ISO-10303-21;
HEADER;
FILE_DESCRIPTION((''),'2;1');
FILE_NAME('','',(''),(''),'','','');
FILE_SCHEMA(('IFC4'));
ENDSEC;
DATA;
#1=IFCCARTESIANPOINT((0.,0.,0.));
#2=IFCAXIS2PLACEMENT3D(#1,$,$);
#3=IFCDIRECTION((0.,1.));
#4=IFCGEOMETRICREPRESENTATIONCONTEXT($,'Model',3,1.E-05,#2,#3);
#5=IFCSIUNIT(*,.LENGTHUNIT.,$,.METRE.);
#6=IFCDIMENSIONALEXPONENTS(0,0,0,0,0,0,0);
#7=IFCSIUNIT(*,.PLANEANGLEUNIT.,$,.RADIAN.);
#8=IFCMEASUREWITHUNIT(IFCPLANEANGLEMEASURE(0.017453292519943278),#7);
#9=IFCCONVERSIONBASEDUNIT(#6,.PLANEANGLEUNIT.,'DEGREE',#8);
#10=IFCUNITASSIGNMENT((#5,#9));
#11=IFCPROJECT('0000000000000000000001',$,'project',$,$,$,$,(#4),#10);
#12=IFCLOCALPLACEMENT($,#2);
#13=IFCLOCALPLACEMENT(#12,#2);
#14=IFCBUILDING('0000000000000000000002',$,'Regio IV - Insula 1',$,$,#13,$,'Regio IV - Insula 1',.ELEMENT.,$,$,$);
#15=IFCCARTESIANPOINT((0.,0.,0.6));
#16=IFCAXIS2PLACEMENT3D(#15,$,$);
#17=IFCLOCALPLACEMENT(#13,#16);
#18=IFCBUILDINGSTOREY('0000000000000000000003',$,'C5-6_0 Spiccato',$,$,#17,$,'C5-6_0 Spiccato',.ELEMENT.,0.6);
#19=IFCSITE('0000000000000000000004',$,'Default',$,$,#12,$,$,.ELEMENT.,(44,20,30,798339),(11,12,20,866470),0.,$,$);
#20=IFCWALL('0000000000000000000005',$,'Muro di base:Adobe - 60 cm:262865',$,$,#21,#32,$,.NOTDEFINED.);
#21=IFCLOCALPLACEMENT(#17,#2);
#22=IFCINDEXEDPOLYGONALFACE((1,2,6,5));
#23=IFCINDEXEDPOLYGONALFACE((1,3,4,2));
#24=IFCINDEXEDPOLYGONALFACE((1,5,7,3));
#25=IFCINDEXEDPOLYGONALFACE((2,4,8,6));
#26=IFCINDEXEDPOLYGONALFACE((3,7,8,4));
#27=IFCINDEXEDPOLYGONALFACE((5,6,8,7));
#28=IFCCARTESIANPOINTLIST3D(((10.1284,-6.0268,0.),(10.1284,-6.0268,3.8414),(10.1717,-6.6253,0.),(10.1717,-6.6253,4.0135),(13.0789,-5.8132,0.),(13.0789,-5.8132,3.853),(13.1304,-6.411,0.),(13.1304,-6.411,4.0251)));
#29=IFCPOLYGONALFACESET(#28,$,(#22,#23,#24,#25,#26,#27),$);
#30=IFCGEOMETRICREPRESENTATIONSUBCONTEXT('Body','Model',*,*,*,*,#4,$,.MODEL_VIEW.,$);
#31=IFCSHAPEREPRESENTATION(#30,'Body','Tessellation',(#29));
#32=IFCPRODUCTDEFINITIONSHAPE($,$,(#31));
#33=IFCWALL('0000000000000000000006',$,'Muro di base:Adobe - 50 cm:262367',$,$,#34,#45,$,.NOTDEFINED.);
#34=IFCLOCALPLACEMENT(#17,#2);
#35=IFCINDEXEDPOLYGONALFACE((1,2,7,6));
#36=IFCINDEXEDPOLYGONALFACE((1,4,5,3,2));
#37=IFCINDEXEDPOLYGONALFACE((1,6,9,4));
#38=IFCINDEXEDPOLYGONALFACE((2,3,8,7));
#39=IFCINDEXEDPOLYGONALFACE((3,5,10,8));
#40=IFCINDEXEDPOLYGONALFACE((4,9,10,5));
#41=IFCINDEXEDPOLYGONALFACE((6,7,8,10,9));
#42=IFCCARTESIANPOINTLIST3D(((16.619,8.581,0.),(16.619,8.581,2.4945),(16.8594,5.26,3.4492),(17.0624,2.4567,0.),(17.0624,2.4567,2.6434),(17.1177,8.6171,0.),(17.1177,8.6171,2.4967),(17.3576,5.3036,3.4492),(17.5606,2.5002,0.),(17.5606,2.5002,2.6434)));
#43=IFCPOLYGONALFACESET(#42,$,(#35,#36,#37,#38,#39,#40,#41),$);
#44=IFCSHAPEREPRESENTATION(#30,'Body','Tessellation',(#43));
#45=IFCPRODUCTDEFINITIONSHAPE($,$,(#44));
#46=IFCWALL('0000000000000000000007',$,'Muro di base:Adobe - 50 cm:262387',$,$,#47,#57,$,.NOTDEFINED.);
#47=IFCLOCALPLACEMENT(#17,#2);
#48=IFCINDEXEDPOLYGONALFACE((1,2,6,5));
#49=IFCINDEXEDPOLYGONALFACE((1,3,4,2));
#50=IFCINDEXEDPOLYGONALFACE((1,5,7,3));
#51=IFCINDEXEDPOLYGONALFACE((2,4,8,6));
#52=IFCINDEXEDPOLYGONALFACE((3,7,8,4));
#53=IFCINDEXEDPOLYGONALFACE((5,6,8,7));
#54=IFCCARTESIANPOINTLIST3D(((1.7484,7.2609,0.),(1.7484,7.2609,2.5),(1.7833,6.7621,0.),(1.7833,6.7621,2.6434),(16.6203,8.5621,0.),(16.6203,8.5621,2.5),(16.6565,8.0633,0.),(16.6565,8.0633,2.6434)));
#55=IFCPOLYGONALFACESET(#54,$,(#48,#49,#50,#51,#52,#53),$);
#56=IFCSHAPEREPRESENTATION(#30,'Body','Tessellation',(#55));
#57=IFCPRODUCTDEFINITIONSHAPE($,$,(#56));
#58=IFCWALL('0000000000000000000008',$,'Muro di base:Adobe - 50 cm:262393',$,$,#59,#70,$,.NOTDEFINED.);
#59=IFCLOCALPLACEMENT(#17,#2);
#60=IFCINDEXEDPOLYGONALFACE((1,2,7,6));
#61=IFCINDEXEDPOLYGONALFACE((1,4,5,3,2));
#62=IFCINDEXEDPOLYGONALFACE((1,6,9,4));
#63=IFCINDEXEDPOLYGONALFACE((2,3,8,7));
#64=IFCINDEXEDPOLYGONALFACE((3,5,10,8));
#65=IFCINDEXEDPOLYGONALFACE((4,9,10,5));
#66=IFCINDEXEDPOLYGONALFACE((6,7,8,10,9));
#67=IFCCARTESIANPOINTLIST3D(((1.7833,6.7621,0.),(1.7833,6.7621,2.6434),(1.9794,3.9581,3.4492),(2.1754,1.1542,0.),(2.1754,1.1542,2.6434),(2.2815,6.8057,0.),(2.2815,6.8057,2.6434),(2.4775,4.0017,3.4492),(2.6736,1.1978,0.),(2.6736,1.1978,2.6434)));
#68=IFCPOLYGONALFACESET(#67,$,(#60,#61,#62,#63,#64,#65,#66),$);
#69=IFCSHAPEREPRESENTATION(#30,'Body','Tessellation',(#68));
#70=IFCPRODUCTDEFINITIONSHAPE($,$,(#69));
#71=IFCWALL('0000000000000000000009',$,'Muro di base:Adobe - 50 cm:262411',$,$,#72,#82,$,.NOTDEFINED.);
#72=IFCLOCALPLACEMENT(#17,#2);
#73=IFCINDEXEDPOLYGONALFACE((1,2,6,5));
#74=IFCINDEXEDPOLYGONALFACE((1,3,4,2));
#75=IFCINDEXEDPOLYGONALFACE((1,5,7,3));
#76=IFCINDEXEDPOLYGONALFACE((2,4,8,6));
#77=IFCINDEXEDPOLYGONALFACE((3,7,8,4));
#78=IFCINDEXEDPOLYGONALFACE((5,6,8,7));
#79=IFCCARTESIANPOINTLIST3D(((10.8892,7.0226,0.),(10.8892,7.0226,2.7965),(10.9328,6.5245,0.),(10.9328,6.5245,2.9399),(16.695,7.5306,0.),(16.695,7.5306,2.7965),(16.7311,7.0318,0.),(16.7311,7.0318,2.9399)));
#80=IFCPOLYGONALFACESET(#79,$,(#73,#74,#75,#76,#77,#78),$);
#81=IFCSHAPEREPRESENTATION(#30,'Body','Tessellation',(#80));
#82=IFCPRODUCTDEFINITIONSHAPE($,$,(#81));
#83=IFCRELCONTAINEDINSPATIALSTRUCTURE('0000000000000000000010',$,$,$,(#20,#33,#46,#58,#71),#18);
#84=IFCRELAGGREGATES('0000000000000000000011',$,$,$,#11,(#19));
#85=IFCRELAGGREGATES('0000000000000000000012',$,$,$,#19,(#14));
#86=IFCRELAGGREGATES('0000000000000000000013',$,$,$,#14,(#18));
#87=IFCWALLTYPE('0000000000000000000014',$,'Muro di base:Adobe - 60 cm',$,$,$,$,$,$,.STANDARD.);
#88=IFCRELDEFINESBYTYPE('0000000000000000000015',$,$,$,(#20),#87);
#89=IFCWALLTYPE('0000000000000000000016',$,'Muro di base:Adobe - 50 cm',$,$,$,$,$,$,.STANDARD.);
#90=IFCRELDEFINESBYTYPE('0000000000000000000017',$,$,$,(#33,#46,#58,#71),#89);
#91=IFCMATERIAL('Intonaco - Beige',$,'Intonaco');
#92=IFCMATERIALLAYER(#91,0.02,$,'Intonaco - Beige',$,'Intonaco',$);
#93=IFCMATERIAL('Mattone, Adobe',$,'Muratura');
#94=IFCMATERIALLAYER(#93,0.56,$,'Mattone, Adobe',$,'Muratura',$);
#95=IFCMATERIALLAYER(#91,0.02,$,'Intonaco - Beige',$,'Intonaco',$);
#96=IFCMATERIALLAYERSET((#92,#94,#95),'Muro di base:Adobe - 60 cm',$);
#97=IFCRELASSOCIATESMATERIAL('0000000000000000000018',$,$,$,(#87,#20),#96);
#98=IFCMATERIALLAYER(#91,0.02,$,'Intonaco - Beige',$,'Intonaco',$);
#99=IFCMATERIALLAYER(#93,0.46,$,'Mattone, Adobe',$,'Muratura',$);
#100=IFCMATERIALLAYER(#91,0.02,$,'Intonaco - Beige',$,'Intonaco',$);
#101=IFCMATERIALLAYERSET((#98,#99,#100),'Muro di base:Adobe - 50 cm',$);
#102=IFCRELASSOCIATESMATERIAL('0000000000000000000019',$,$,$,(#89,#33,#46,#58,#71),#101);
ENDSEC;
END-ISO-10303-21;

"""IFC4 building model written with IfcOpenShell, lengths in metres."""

from ifc_helpers import new_model, entity, si_unit, converted_unit, direction, frame, origin, place, context, subcontext, project, spatial, polyline, outline, extrude, clip, bounded_halfspace, material, layer, layer_set, layer_usage, type_object, element, save


model = new_model("IFC4")

# Units and contexts
model_context = context("Model", 3, precision=1e-05, world=origin(), true_north=direction((0.0, 1.0)))
body_context = subcontext(model_context, "Body", "Model", "MODEL_VIEW")
ifc_project = project(units=[si_unit("LENGTHUNIT", "METRE"), converted_unit("PLANEANGLEUNIT", "DEGREE", entity("IfcPlaneAngleMeasure", 0.017453292519943278), si_unit("PLANEANGLEUNIT", "RADIAN"), dimensions=[0, 0, 0, 0, 0, 0, 0])], contexts=[model_context])

# Site, building, storey
site_placement = place(None, origin())
site = spatial("IfcSite", under=ifc_project, at=site_placement, Name="Default", CompositionType="ELEMENT", RefLatitude=(44, 20, 30, 798339), RefLongitude=(11, 12, 20, 866470), RefElevation=0.0)
building_placement = place(site_placement, origin())
building = spatial("IfcBuilding", under=site, at=building_placement, Name="Regio IV - Insula 1", LongName="Regio IV - Insula 1", CompositionType="ELEMENT")
storey_placement = place(building_placement, frame((0.0, 0.0, 0.6)))
storey = spatial("IfcBuildingStorey", under=building, at=storey_placement, Name="C5-6_0 Spiccato", LongName="C5-6_0 Spiccato", CompositionType="ELEMENT", Elevation=0.6)

# Walls
ifc_material_1 = material(Name="Intonaco - Beige", Category="Intonaco")
ifc_layer_1 = layer(ifc_material_1, 0.02, Name="Intonaco - Beige", Category="Intonaco")
ifc_material_2 = material(Name="Mattone, Adobe", Category="Muratura")
ifc_layer_2 = layer(ifc_material_2, 0.56, Name="Mattone, Adobe", Category="Muratura")
ifc_layer_3 = layer(ifc_material_1, 0.02, Name="Intonaco - Beige", Category="Intonaco")
ifc_layer_set_1 = layer_set([ifc_layer_1, ifc_layer_2, ifc_layer_3], Name="Muro di base:Adobe - 60 cm")
ifc_layer_usage_1 = layer_usage(ifc_layer_set_1, "AXIS2", "NEGATIVE", 0.3)
wall_type_1 = type_object("IfcWallType", Name="Muro di base:Adobe - 60 cm", PredefinedType="STANDARD", material=ifc_layer_set_1)
wall_1_placement = place(storey_placement, frame((10.15, -6.3261, 0.0), z_axis=(0.0, 0.0, 1.0), x_axis=(0.997389, 0.07222, 0.0)))
element("IfcWall", 1, at=wall_1_placement, inside=storey, type_object=wall_type_1, material=ifc_layer_usage_1, Name="Muro di base:Adobe - 60 cm:262865", PredefinedType="NOTDEFINED", context=body_context, shape_type="Clipping", body=[
    clip(extrude(outline(polyline([(2.9664, -0.3), (2.9582, 0.3), (0.0, 0.3), (0.0, -0.3), (2.9664, -0.3)])), origin(), (0.0, 0.0, 1.0), 4.0251), bounded_halfspace(frame((0.0, -0.3, 4.0135), z_axis=(-0.003755, 0.275612, 0.961262), x_axis=(-0.999907, -0.013623, 0.0)), False, frame((0.0, -0.3, 4.0135)), polyline([(0.0, 0.0), (2.9664, 0.0), (2.9582, 0.6), (0.0, 0.6), (0.0, 0.0)]))),
])
ifc_layer_4 = layer(ifc_material_1, 0.02, Name="Intonaco - Beige", Category="Intonaco")
ifc_layer_5 = layer(ifc_material_2, 0.46, Name="Mattone, Adobe", Category="Muratura")
ifc_layer_6 = layer(ifc_material_1, 0.02, Name="Intonaco - Beige", Category="Intonaco")
ifc_layer_set_2 = layer_set([ifc_layer_4, ifc_layer_5, ifc_layer_6], Name="Muro di base:Adobe - 50 cm")
ifc_layer_usage_2 = layer_usage(ifc_layer_set_2, "AXIS2", "NEGATIVE", 0.25)
wall_type_2 = type_object("IfcWallType", Name="Muro di base:Adobe - 50 cm", PredefinedType="STANDARD", material=ifc_layer_set_2)
wall_2_placement = place(storey_placement, frame((17.3118, 2.4747, 0.0), z_axis=(0.0, 0.0, 1.0), x_axis=(-0.07222, 0.997389, 0.0)))
element("IfcWall", 2, at=wall_2_placement, inside=storey, type_object=wall_type_2, material=ifc_layer_usage_2, Name="Muro di base:Adobe - 50 cm:262367", PredefinedType="NOTDEFINED", context=body_context, shape_type="Clipping", body=[
    clip(clip(extrude(outline(polyline([(6.1404, -0.25), (6.1404, 0.25), (6.1214, 0.25), (5.6213, 0.25), (5.0872, 0.25), (4.5871, 0.25), (0.0, 0.25), (0.0074, -0.2462), (0.0075, -0.25), (6.1404, -0.25)])), origin(), (0.0, 0.0, 1.0), 3.4492), bounded_halfspace(frame((2.8182, -0.25, 3.4492), z_axis=(0.275606, 0.00413, 0.961262), x_axis=(-0.014983, 0.999888, 0.0)), False, frame((2.8182, -0.25, 3.4492)), polyline([(0.0, 0.0), (3.3222, 0.0), (3.3222, 0.5), (3.3032, 0.5), (2.8032, 0.5), (2.269, 0.5), (1.769, 0.5), (-0.0075, 0.5), (0.0, 0.0)]))), bounded_halfspace(frame((0.0075, -0.25, 2.6434), z_axis=(-0.275606, -0.00413, 0.961262), x_axis=(0.014983, -0.999888, 0.0)), False, frame((0.0075, -0.25, 2.6434)), polyline([(0.0, 0.0), (2.8107, 0.0), (2.8032, 0.5), (-0.0075, 0.5), (0.0, 0.0)]))),
])
ifc_layer_usage_3 = layer_usage(ifc_layer_set_2, "AXIS2", "NEGATIVE", 0.25)
wall_3_placement = place(storey_placement, frame((1.7615, 7.0111, 0.0), z_axis=(0.0, 0.0, 1.0), x_axis=(0.996195, 0.087156, 0.0)))
element("IfcWall", 3, at=wall_3_placement, inside=storey, type_object=wall_type_2, material=ifc_layer_usage_3, Name="Muro di base:Adobe - 50 cm:262387", PredefinedType="NOTDEFINED", context=body_context, shape_type="Clipping", body=[
    clip(extrude(outline(polyline([(14.93, -0.25), (14.9375, 0.25), (0.0087, 0.25), (0.0, -0.25), (0.5001, -0.25), (4.6739, -0.25), (5.1739, -0.25), (8.594, -0.25), (9.094, -0.25), (14.93, -0.25)])), origin(), (0.0, 0.0, 1.0), 2.6434), bounded_halfspace(frame((0.0, -0.25, 2.6434), z_axis=(0.0, 0.275637, 0.961262), x_axis=(-1.0, 0.0, 0.0)), False, frame((0.0, -0.25, 2.6434)), polyline([(0.0, 0.0), (0.5001, 0.0), (4.6739, 0.0), (5.1739, 0.0), (8.594, 0.0), (9.094, 0.0), (14.93, 0.0), (14.9375, 0.5), (0.0087, 0.5), (0.0, 0.0)]))),
])
ifc_layer_usage_4 = layer_usage(ifc_layer_set_2, "AXIS2", "NEGATIVE", 0.25)
wall_4_placement = place(storey_placement, frame((2.4248, 1.1717, 0.0), z_axis=(0.0, 0.0, 1.0), x_axis=(-0.069756, 0.997564, 0.0)))
element("IfcWall", 4, at=wall_4_placement, inside=storey, type_object=wall_type_2, material=ifc_layer_usage_4, Name="Muro di base:Adobe - 50 cm:262393", PredefinedType="NOTDEFINED", context=body_context, shape_type="Clipping", body=[
    clip(clip(extrude(outline(polyline([(5.6303, -0.25), (5.6215, 0.25), (0.0, 0.25), (0.0087, -0.25), (5.6303, -0.25)])), origin(), (0.0, 0.0, 1.0), 3.4492), bounded_halfspace(frame((2.8195, -0.25, 3.4492), z_axis=(0.275595, 0.004811, 0.961262), x_axis=(-0.017452, 0.999848, 0.0)), False, frame((2.8195, -0.25, 3.4492)), polyline([(0.0, 0.0), (2.8108, 0.0), (2.802, 0.5), (-0.0087, 0.5), (0.0, 0.0)]))), bounded_halfspace(frame((0.0087, -0.25, 2.6434), z_axis=(-0.275595, -0.004811, 0.961262), x_axis=(0.017452, -0.999848, 0.0)), False, frame((0.0087, -0.25, 2.6434)), polyline([(0.0, 0.0), (2.8108, 0.0), (2.802, 0.5), (-0.0087, 0.5), (0.0, 0.0)]))),
])

# Wall
ifc_layer_usage_5 = layer_usage(ifc_layer_set_2, "AXIS2", "NEGATIVE", 0.25)
wall_5_placement = place(storey_placement, frame((10.911, 6.7736, 0.0), z_axis=(0.0, 0.0, 1.0), x_axis=(0.996195, 0.087156, 0.0)))
element("IfcWall", 5, at=wall_5_placement, inside=storey, type_object=wall_type_2, material=ifc_layer_usage_5, Name="Muro di base:Adobe - 50 cm:262411", PredefinedType="NOTDEFINED", context=body_context, shape_type="Clipping", body=[
    clip(extrude(outline(polyline([(5.8205, -0.25), (5.828, 0.25), (0.0, 0.25), (0.0, -0.25), (5.8205, -0.25)])), origin(), (0.0, 0.0, 1.0), 2.9399), bounded_halfspace(frame((0.0, -0.25, 2.9399), z_axis=(0.0, 0.275637, 0.961262), x_axis=(-1.0, 0.0, 0.0)), False, frame((0.0, -0.25, 2.9399)), polyline([(0.0, 0.0), (5.8205, 0.0), (5.828, 0.5), (0.0, 0.5), (0.0, 0.0)]))),
])

save(model, "model.ifc")
